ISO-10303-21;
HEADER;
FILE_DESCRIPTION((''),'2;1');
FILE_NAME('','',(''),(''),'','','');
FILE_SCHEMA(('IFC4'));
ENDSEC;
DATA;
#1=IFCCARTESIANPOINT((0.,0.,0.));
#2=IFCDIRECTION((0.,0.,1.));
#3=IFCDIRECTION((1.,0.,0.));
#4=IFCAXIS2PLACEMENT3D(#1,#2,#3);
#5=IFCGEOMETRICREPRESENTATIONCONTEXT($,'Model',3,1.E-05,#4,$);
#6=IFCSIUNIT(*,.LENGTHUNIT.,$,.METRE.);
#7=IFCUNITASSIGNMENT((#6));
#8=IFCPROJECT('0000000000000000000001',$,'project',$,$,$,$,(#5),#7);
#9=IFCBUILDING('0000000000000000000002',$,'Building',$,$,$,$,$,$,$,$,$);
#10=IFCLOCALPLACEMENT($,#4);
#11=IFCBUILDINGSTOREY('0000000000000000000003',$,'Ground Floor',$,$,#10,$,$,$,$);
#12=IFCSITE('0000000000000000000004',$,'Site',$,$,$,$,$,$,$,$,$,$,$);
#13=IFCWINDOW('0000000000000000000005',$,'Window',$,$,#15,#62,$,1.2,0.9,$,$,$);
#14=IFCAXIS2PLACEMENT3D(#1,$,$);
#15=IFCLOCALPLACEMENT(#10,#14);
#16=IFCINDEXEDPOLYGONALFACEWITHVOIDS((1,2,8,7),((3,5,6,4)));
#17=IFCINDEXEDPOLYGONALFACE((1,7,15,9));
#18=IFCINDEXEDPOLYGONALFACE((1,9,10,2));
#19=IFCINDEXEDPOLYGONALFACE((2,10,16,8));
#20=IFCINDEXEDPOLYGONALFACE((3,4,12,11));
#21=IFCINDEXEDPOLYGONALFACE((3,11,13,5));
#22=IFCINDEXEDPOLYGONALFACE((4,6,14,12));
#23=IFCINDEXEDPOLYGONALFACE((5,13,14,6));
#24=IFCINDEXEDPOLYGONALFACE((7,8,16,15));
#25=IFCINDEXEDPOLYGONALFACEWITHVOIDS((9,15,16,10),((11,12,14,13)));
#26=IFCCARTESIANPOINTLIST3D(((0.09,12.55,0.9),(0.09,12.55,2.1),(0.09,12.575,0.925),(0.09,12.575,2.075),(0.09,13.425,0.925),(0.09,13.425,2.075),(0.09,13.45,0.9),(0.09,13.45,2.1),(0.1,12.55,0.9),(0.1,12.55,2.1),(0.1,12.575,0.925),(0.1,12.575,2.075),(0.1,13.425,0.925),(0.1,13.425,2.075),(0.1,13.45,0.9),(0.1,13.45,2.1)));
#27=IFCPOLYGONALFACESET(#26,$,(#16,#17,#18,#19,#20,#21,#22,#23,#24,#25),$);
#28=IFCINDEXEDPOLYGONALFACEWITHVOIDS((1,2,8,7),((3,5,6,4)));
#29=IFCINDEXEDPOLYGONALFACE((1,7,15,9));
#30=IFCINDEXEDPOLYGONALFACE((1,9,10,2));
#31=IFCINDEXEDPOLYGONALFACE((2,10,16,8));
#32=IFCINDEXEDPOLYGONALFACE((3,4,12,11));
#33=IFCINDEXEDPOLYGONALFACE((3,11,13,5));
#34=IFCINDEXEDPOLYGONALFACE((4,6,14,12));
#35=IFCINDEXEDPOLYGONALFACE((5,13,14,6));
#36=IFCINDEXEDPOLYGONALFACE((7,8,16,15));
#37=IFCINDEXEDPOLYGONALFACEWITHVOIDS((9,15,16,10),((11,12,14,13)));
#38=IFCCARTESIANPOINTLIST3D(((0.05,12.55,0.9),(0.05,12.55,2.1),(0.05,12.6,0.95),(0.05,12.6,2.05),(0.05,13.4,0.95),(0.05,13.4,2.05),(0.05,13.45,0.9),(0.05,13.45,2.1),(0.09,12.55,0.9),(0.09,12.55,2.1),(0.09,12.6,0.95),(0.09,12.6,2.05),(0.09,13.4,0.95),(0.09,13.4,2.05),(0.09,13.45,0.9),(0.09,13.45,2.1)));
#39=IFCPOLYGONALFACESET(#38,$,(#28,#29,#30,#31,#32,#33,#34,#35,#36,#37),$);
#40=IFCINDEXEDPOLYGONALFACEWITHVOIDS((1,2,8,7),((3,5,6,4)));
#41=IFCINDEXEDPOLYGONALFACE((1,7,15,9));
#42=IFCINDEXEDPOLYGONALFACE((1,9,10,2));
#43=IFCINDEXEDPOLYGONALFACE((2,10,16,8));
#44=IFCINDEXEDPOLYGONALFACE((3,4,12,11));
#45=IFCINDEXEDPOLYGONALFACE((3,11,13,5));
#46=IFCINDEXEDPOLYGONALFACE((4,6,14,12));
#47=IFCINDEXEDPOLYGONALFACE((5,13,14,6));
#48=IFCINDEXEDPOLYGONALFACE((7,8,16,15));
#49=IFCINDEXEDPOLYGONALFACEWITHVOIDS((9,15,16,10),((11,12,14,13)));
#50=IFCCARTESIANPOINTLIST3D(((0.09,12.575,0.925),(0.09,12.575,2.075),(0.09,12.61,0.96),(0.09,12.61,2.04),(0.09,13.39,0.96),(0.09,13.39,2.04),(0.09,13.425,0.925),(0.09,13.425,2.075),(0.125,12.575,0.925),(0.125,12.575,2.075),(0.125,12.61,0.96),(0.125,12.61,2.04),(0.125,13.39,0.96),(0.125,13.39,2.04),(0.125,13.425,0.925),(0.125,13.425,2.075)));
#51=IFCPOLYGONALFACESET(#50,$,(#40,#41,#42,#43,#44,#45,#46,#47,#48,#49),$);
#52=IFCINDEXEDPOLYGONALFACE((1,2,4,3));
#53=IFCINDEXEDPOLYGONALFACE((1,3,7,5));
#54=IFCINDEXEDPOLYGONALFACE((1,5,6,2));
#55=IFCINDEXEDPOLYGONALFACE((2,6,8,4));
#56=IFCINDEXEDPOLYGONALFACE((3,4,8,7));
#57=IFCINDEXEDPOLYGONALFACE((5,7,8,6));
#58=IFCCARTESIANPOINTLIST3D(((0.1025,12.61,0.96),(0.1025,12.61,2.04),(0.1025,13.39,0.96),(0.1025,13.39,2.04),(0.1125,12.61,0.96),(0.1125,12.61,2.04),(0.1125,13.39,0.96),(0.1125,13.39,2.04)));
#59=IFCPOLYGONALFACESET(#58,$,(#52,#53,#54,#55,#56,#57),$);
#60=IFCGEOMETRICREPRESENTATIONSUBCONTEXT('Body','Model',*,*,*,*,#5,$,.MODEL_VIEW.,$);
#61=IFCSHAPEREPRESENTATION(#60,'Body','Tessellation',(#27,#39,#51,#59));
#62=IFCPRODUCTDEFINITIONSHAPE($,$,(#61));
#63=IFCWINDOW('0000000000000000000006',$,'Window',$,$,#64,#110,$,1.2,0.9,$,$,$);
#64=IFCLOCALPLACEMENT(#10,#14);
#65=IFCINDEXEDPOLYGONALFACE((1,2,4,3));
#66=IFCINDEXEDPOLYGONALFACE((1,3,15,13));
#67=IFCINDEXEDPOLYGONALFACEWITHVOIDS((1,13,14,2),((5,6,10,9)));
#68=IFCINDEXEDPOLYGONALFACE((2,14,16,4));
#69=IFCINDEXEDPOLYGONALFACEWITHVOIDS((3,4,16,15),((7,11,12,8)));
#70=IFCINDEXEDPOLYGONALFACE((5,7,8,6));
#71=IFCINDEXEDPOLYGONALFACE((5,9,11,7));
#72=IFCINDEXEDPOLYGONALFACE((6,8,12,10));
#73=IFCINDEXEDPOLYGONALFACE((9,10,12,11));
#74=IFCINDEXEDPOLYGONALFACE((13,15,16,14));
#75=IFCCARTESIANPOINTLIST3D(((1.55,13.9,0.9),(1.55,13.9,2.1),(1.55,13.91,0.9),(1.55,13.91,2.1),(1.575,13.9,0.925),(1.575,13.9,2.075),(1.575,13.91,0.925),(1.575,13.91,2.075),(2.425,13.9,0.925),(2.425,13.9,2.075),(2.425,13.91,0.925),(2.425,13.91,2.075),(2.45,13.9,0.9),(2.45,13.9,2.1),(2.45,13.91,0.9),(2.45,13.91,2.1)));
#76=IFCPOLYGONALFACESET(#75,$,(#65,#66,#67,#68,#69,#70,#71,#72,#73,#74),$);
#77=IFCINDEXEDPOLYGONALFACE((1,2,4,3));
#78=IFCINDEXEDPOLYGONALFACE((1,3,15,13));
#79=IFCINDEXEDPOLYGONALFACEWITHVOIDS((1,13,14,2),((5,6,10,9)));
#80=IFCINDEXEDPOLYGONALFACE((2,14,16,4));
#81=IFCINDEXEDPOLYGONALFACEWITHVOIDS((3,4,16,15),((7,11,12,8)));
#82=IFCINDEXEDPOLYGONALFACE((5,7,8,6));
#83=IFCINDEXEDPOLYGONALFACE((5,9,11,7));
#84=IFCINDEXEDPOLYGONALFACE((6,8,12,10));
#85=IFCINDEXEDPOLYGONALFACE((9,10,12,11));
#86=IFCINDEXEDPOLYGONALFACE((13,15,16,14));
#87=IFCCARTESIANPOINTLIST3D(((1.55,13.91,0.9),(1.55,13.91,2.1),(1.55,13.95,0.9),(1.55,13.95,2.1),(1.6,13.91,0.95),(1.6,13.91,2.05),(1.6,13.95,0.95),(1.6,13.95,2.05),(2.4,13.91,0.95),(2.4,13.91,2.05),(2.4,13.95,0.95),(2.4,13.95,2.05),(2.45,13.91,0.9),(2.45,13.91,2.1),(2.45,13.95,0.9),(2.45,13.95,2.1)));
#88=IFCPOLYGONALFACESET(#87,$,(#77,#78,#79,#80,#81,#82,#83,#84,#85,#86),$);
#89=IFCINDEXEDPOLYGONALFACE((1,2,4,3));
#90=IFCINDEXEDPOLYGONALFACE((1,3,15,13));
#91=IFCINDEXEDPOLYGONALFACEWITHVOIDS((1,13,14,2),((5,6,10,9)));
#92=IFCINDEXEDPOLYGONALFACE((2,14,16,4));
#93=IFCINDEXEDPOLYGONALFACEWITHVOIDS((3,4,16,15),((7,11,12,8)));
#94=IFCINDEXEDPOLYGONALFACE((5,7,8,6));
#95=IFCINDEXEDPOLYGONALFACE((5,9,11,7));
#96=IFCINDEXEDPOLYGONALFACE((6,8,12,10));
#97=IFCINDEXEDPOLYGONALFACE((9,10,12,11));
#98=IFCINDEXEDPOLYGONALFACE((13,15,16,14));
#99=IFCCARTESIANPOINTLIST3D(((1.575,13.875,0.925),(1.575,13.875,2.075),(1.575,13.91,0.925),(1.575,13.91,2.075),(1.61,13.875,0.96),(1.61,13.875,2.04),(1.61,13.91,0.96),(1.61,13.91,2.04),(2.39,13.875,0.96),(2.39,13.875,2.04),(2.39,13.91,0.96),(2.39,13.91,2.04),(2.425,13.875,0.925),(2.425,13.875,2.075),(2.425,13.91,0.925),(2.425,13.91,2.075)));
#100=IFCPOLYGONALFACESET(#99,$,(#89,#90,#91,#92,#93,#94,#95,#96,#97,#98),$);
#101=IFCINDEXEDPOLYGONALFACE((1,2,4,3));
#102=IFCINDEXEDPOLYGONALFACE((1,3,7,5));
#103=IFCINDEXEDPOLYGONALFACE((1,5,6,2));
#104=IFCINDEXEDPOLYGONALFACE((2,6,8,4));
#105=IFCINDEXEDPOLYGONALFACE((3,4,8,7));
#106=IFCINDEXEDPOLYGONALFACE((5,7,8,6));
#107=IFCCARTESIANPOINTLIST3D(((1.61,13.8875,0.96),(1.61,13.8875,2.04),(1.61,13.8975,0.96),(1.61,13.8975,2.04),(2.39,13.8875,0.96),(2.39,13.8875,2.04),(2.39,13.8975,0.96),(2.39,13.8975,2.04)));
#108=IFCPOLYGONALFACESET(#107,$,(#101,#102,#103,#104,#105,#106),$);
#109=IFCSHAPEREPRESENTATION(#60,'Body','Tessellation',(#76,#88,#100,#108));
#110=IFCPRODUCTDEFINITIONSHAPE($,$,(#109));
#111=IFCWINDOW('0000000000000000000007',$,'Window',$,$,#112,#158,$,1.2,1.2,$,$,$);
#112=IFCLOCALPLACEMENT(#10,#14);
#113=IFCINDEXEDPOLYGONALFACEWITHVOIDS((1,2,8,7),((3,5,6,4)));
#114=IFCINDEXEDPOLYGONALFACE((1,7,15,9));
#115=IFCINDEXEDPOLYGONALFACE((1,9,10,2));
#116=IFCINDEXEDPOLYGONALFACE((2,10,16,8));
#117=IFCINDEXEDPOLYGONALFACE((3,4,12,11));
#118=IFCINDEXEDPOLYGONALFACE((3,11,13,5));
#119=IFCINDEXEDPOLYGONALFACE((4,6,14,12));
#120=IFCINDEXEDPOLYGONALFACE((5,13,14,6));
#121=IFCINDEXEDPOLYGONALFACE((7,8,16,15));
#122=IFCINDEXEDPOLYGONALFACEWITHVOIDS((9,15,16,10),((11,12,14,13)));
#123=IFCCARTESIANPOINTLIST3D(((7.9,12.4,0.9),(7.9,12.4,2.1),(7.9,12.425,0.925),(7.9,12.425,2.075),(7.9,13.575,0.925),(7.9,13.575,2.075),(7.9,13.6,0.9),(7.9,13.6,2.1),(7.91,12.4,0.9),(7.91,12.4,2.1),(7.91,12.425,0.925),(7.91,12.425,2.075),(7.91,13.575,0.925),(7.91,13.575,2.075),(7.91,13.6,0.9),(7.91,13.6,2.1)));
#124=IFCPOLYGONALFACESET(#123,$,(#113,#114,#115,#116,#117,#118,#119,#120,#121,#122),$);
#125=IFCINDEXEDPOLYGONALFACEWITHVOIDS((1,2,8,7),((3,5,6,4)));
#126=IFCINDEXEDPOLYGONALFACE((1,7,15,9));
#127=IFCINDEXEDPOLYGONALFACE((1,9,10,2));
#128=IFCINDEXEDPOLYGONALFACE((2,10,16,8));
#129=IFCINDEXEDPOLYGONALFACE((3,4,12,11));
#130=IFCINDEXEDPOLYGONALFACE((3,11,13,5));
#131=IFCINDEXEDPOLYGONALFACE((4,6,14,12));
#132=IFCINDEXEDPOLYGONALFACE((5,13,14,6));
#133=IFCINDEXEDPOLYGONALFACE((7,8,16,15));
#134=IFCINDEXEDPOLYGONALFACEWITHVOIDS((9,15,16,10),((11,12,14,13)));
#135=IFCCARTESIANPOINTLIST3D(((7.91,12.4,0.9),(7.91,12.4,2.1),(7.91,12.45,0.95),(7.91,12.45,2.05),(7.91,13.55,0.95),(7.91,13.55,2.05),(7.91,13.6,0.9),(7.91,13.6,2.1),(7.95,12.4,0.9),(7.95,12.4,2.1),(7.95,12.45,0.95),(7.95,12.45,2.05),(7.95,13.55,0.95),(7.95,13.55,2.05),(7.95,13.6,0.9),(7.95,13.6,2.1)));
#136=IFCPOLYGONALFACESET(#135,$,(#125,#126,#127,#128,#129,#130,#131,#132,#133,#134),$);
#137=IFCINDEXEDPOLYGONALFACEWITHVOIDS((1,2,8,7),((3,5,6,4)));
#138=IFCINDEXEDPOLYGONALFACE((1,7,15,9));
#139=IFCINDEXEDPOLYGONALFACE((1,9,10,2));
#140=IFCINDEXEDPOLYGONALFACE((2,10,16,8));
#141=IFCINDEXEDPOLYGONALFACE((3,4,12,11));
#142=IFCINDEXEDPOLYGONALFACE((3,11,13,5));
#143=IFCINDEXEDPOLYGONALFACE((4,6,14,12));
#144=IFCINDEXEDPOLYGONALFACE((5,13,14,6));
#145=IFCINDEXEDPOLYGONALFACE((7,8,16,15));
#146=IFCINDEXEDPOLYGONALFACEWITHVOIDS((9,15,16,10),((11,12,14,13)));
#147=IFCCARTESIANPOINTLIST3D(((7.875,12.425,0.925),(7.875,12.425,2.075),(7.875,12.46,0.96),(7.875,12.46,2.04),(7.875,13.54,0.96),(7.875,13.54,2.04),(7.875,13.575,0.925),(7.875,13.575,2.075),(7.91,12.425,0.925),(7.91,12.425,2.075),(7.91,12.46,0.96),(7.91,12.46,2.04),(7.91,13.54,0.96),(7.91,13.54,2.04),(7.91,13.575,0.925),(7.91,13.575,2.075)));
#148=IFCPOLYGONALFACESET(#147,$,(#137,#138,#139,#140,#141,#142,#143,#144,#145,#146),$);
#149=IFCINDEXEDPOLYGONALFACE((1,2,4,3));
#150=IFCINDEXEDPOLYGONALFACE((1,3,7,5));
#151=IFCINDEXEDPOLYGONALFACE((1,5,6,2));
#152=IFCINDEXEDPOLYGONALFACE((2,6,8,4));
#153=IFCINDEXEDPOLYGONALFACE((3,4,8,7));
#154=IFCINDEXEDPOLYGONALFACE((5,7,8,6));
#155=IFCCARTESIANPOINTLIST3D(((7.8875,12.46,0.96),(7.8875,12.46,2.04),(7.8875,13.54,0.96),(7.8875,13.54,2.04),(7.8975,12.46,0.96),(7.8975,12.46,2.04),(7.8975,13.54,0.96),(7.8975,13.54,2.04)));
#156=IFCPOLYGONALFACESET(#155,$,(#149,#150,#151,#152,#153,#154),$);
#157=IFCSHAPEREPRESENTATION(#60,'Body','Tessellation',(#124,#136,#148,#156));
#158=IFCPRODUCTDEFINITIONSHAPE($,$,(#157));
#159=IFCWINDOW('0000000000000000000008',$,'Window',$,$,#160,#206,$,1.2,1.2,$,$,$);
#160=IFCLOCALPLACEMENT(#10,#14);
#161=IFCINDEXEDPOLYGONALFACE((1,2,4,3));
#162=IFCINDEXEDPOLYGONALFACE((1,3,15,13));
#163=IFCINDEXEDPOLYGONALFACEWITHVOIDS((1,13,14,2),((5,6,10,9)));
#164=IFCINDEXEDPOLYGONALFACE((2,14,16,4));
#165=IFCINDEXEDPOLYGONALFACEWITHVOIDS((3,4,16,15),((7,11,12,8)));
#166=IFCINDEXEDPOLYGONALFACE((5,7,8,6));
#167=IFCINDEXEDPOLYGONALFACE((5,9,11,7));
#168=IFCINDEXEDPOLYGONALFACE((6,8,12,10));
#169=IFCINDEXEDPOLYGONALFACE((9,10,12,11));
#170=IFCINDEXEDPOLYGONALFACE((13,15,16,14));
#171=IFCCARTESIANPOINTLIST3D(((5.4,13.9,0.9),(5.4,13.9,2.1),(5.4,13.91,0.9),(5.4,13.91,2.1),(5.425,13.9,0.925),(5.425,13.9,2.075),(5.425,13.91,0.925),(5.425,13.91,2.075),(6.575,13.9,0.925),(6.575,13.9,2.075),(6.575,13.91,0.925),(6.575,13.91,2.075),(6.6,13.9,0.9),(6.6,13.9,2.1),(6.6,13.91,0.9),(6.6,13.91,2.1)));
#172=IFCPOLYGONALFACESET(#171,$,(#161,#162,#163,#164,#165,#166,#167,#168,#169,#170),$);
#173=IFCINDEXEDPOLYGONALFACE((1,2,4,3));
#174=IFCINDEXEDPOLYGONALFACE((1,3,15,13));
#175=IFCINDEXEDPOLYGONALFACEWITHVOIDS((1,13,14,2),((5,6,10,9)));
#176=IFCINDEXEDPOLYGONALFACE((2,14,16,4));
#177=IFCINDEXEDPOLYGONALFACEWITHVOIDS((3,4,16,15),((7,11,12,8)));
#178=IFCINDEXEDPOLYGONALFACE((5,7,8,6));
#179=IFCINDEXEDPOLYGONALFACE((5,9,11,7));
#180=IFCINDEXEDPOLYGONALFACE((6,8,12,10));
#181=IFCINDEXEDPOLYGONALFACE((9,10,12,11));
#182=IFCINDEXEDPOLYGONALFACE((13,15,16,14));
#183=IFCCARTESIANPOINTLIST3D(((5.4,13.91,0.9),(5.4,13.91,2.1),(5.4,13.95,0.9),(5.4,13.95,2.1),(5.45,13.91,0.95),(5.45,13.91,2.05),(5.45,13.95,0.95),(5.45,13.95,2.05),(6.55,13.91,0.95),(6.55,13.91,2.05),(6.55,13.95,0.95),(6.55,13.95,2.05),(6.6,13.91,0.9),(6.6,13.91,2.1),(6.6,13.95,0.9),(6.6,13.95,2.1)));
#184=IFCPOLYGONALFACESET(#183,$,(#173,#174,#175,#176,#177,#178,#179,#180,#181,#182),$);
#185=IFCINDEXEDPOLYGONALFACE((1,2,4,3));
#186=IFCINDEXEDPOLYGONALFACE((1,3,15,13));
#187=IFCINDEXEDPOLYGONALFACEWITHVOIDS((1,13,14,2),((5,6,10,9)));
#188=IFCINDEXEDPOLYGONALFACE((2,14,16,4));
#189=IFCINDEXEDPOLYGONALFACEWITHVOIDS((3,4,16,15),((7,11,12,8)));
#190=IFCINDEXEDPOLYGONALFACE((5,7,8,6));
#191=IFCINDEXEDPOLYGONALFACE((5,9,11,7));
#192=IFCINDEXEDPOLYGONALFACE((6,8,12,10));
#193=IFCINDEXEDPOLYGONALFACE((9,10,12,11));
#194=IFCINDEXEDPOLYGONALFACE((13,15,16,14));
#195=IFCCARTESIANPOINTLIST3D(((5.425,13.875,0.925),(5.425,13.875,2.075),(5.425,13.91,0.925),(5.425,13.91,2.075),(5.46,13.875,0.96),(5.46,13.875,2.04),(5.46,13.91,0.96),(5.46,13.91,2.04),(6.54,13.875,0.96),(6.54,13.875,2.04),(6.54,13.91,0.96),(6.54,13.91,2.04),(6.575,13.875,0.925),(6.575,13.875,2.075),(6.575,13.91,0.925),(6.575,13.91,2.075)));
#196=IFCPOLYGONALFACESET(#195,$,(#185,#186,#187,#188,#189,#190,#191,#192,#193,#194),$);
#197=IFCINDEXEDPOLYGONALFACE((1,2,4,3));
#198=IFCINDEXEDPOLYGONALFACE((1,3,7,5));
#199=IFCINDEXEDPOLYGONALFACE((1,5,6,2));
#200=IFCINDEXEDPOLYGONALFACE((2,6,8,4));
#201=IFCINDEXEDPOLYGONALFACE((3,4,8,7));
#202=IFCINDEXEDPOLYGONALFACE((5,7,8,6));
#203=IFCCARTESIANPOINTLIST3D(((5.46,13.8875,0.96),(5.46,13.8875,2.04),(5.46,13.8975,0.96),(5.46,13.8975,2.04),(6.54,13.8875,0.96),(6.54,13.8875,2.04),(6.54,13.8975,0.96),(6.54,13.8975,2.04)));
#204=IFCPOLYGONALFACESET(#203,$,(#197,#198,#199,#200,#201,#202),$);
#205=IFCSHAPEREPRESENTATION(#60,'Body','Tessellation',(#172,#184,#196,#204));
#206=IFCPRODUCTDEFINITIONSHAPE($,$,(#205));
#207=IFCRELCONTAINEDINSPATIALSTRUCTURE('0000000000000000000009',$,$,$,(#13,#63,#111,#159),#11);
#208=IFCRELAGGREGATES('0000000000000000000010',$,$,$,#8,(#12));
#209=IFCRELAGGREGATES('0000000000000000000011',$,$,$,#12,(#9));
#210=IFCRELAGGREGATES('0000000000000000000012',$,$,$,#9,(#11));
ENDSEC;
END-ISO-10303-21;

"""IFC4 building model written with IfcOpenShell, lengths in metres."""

from ifc_helpers import new_model, si_unit, frame, origin_with_axes, place, context, subcontext, project, spatial, line, indexed_curve, outline, extrude, element, save


model = new_model("IFC4")

# Units and contexts
model_context = context("Model", 3, precision=1e-05, world=origin_with_axes())
body_context = subcontext(model_context, "Body", "Model", "MODEL_VIEW")
ifc_project = project(units=[si_unit("LENGTHUNIT", "METRE")], contexts=[model_context])

# Site, building, storey
site = spatial("IfcSite", under=ifc_project, Name="Site")
building = spatial("IfcBuilding", under=site, Name="Building")
storey_placement = place(None, origin_with_axes())
storey = spatial("IfcBuildingStorey", under=building, at=storey_placement, Name="Ground Floor")

# Windows
for number, where, z_axis, x_axis, name in (
    (1, (0.0, 13.45, 0.9), (0.0, 0.0, 1.0), (0.0, -1.0, 0.0), "Window"),
    (2, (2.45, 14.0, 0.9), (0.0, 0.0, 1.0), (-1.0, 0.0, 0.0), "Window"),
):
    element("IfcWindow", number, at=place(storey_placement, frame(where, z_axis=z_axis, x_axis=x_axis)), inside=storey, Name=name, OverallHeight=1.2, OverallWidth=0.9, context=body_context, shape_type="SweptSolid", body=[
        extrude(outline(indexed_curve([(0.0, 0.0), (0.9, 0.0), (0.9, 1.2), (0.0, 1.2)], segments=[line(1, 2, 3, 4, 1)]), holes=[indexed_curve([(0.025, 0.025), (0.875, 0.025), (0.875, 1.175), (0.025, 1.175)], segments=[line(1, 2, 3, 4, 1)])]), frame((0.0, 0.09, 0.0), z_axis=(0.0, -1.0, 0.0), x_axis=(1.0, 0.0, 0.0)), (0.0, 0.0, -1.0), 0.01),
        extrude(outline(indexed_curve([(0.0, 0.0), (0.9, 0.0), (0.9, 1.2), (0.0, 1.2)], segments=[line(1, 2, 3, 4, 1)]), holes=[indexed_curve([(0.05, 0.05), (0.85, 0.05), (0.85, 1.15), (0.05, 1.15)], segments=[line(1, 2, 3, 4, 1)])]), frame((0.0, 0.05, 0.0), z_axis=(0.0, -1.0, 0.0), x_axis=(1.0, 0.0, 0.0)), (0.0, 0.0, -1.0), 0.04),
        extrude(outline(indexed_curve([(0.0, 0.0), (0.85, 0.0), (0.85, 1.15), (0.0, 1.15)], segments=[line(1, 2, 3, 4, 1)]), holes=[indexed_curve([(0.035, 0.035), (0.815, 0.035), (0.815, 1.115), (0.035, 1.115)], segments=[line(1, 2, 3, 4, 1)])]), frame((0.025, 0.09, 0.025), z_axis=(0.0, -1.0, 0.0), x_axis=(1.0, 0.0, 0.0)), (0.0, 0.0, -1.0), 0.035),
        extrude(outline(indexed_curve([(0.035, 0.035), (0.815, 0.035), (0.815, 1.115), (0.035, 1.115)], segments=[line(1, 2, 3, 4, 1)])), frame((0.025, 0.1025, 0.025), z_axis=(0.0, -1.0, 0.0), x_axis=(1.0, 0.0, 0.0)), (0.0, 0.0, -1.0), 0.01),
    ])
for number, where, z_axis, x_axis, name in (
    (3, (8.0, 12.4, 0.9), (0.0, 0.0, 1.0), (0.0, 1.0, 0.0), "Window"),
    (4, (6.6, 14.0, 0.9), (0.0, 0.0, 1.0), (-1.0, 0.0, 0.0), "Window"),
):
    element("IfcWindow", number, at=place(storey_placement, frame(where, z_axis=z_axis, x_axis=x_axis)), inside=storey, Name=name, OverallHeight=1.2, OverallWidth=1.2, context=body_context, shape_type="SweptSolid", body=[
        extrude(outline(indexed_curve([(0.0, 0.0), (1.2, 0.0), (1.2, 1.2), (0.0, 1.2)], segments=[line(1, 2, 3, 4, 1)]), holes=[indexed_curve([(0.025, 0.025), (1.175, 0.025), (1.175, 1.175), (0.025, 1.175)], segments=[line(1, 2, 3, 4, 1)])]), frame((0.0, 0.09, 0.0), z_axis=(0.0, -1.0, 0.0), x_axis=(1.0, 0.0, 0.0)), (0.0, 0.0, -1.0), 0.01),
        extrude(outline(indexed_curve([(0.0, 0.0), (1.2, 0.0), (1.2, 1.2), (0.0, 1.2)], segments=[line(1, 2, 3, 4, 1)]), holes=[indexed_curve([(0.05, 0.05), (1.15, 0.05), (1.15, 1.15), (0.05, 1.15)], segments=[line(1, 2, 3, 4, 1)])]), frame((0.0, 0.05, 0.0), z_axis=(0.0, -1.0, 0.0), x_axis=(1.0, 0.0, 0.0)), (0.0, 0.0, -1.0), 0.04),
        extrude(outline(indexed_curve([(0.0, 0.0), (1.15, 0.0), (1.15, 1.15), (0.0, 1.15)], segments=[line(1, 2, 3, 4, 1)]), holes=[indexed_curve([(0.035, 0.035), (1.115, 0.035), (1.115, 1.115), (0.035, 1.115)], segments=[line(1, 2, 3, 4, 1)])]), frame((0.025, 0.09, 0.025), z_axis=(0.0, -1.0, 0.0), x_axis=(1.0, 0.0, 0.0)), (0.0, 0.0, -1.0), 0.035),
        extrude(outline(indexed_curve([(0.035, 0.035), (1.115, 0.035), (1.115, 1.115), (0.035, 1.115)], segments=[line(1, 2, 3, 4, 1)])), frame((0.025, 0.1025, 0.025), z_axis=(0.0, -1.0, 0.0), x_axis=(1.0, 0.0, 0.0)), (0.0, 0.0, -1.0), 0.01),
    ])

save(model, "model.ifc")
